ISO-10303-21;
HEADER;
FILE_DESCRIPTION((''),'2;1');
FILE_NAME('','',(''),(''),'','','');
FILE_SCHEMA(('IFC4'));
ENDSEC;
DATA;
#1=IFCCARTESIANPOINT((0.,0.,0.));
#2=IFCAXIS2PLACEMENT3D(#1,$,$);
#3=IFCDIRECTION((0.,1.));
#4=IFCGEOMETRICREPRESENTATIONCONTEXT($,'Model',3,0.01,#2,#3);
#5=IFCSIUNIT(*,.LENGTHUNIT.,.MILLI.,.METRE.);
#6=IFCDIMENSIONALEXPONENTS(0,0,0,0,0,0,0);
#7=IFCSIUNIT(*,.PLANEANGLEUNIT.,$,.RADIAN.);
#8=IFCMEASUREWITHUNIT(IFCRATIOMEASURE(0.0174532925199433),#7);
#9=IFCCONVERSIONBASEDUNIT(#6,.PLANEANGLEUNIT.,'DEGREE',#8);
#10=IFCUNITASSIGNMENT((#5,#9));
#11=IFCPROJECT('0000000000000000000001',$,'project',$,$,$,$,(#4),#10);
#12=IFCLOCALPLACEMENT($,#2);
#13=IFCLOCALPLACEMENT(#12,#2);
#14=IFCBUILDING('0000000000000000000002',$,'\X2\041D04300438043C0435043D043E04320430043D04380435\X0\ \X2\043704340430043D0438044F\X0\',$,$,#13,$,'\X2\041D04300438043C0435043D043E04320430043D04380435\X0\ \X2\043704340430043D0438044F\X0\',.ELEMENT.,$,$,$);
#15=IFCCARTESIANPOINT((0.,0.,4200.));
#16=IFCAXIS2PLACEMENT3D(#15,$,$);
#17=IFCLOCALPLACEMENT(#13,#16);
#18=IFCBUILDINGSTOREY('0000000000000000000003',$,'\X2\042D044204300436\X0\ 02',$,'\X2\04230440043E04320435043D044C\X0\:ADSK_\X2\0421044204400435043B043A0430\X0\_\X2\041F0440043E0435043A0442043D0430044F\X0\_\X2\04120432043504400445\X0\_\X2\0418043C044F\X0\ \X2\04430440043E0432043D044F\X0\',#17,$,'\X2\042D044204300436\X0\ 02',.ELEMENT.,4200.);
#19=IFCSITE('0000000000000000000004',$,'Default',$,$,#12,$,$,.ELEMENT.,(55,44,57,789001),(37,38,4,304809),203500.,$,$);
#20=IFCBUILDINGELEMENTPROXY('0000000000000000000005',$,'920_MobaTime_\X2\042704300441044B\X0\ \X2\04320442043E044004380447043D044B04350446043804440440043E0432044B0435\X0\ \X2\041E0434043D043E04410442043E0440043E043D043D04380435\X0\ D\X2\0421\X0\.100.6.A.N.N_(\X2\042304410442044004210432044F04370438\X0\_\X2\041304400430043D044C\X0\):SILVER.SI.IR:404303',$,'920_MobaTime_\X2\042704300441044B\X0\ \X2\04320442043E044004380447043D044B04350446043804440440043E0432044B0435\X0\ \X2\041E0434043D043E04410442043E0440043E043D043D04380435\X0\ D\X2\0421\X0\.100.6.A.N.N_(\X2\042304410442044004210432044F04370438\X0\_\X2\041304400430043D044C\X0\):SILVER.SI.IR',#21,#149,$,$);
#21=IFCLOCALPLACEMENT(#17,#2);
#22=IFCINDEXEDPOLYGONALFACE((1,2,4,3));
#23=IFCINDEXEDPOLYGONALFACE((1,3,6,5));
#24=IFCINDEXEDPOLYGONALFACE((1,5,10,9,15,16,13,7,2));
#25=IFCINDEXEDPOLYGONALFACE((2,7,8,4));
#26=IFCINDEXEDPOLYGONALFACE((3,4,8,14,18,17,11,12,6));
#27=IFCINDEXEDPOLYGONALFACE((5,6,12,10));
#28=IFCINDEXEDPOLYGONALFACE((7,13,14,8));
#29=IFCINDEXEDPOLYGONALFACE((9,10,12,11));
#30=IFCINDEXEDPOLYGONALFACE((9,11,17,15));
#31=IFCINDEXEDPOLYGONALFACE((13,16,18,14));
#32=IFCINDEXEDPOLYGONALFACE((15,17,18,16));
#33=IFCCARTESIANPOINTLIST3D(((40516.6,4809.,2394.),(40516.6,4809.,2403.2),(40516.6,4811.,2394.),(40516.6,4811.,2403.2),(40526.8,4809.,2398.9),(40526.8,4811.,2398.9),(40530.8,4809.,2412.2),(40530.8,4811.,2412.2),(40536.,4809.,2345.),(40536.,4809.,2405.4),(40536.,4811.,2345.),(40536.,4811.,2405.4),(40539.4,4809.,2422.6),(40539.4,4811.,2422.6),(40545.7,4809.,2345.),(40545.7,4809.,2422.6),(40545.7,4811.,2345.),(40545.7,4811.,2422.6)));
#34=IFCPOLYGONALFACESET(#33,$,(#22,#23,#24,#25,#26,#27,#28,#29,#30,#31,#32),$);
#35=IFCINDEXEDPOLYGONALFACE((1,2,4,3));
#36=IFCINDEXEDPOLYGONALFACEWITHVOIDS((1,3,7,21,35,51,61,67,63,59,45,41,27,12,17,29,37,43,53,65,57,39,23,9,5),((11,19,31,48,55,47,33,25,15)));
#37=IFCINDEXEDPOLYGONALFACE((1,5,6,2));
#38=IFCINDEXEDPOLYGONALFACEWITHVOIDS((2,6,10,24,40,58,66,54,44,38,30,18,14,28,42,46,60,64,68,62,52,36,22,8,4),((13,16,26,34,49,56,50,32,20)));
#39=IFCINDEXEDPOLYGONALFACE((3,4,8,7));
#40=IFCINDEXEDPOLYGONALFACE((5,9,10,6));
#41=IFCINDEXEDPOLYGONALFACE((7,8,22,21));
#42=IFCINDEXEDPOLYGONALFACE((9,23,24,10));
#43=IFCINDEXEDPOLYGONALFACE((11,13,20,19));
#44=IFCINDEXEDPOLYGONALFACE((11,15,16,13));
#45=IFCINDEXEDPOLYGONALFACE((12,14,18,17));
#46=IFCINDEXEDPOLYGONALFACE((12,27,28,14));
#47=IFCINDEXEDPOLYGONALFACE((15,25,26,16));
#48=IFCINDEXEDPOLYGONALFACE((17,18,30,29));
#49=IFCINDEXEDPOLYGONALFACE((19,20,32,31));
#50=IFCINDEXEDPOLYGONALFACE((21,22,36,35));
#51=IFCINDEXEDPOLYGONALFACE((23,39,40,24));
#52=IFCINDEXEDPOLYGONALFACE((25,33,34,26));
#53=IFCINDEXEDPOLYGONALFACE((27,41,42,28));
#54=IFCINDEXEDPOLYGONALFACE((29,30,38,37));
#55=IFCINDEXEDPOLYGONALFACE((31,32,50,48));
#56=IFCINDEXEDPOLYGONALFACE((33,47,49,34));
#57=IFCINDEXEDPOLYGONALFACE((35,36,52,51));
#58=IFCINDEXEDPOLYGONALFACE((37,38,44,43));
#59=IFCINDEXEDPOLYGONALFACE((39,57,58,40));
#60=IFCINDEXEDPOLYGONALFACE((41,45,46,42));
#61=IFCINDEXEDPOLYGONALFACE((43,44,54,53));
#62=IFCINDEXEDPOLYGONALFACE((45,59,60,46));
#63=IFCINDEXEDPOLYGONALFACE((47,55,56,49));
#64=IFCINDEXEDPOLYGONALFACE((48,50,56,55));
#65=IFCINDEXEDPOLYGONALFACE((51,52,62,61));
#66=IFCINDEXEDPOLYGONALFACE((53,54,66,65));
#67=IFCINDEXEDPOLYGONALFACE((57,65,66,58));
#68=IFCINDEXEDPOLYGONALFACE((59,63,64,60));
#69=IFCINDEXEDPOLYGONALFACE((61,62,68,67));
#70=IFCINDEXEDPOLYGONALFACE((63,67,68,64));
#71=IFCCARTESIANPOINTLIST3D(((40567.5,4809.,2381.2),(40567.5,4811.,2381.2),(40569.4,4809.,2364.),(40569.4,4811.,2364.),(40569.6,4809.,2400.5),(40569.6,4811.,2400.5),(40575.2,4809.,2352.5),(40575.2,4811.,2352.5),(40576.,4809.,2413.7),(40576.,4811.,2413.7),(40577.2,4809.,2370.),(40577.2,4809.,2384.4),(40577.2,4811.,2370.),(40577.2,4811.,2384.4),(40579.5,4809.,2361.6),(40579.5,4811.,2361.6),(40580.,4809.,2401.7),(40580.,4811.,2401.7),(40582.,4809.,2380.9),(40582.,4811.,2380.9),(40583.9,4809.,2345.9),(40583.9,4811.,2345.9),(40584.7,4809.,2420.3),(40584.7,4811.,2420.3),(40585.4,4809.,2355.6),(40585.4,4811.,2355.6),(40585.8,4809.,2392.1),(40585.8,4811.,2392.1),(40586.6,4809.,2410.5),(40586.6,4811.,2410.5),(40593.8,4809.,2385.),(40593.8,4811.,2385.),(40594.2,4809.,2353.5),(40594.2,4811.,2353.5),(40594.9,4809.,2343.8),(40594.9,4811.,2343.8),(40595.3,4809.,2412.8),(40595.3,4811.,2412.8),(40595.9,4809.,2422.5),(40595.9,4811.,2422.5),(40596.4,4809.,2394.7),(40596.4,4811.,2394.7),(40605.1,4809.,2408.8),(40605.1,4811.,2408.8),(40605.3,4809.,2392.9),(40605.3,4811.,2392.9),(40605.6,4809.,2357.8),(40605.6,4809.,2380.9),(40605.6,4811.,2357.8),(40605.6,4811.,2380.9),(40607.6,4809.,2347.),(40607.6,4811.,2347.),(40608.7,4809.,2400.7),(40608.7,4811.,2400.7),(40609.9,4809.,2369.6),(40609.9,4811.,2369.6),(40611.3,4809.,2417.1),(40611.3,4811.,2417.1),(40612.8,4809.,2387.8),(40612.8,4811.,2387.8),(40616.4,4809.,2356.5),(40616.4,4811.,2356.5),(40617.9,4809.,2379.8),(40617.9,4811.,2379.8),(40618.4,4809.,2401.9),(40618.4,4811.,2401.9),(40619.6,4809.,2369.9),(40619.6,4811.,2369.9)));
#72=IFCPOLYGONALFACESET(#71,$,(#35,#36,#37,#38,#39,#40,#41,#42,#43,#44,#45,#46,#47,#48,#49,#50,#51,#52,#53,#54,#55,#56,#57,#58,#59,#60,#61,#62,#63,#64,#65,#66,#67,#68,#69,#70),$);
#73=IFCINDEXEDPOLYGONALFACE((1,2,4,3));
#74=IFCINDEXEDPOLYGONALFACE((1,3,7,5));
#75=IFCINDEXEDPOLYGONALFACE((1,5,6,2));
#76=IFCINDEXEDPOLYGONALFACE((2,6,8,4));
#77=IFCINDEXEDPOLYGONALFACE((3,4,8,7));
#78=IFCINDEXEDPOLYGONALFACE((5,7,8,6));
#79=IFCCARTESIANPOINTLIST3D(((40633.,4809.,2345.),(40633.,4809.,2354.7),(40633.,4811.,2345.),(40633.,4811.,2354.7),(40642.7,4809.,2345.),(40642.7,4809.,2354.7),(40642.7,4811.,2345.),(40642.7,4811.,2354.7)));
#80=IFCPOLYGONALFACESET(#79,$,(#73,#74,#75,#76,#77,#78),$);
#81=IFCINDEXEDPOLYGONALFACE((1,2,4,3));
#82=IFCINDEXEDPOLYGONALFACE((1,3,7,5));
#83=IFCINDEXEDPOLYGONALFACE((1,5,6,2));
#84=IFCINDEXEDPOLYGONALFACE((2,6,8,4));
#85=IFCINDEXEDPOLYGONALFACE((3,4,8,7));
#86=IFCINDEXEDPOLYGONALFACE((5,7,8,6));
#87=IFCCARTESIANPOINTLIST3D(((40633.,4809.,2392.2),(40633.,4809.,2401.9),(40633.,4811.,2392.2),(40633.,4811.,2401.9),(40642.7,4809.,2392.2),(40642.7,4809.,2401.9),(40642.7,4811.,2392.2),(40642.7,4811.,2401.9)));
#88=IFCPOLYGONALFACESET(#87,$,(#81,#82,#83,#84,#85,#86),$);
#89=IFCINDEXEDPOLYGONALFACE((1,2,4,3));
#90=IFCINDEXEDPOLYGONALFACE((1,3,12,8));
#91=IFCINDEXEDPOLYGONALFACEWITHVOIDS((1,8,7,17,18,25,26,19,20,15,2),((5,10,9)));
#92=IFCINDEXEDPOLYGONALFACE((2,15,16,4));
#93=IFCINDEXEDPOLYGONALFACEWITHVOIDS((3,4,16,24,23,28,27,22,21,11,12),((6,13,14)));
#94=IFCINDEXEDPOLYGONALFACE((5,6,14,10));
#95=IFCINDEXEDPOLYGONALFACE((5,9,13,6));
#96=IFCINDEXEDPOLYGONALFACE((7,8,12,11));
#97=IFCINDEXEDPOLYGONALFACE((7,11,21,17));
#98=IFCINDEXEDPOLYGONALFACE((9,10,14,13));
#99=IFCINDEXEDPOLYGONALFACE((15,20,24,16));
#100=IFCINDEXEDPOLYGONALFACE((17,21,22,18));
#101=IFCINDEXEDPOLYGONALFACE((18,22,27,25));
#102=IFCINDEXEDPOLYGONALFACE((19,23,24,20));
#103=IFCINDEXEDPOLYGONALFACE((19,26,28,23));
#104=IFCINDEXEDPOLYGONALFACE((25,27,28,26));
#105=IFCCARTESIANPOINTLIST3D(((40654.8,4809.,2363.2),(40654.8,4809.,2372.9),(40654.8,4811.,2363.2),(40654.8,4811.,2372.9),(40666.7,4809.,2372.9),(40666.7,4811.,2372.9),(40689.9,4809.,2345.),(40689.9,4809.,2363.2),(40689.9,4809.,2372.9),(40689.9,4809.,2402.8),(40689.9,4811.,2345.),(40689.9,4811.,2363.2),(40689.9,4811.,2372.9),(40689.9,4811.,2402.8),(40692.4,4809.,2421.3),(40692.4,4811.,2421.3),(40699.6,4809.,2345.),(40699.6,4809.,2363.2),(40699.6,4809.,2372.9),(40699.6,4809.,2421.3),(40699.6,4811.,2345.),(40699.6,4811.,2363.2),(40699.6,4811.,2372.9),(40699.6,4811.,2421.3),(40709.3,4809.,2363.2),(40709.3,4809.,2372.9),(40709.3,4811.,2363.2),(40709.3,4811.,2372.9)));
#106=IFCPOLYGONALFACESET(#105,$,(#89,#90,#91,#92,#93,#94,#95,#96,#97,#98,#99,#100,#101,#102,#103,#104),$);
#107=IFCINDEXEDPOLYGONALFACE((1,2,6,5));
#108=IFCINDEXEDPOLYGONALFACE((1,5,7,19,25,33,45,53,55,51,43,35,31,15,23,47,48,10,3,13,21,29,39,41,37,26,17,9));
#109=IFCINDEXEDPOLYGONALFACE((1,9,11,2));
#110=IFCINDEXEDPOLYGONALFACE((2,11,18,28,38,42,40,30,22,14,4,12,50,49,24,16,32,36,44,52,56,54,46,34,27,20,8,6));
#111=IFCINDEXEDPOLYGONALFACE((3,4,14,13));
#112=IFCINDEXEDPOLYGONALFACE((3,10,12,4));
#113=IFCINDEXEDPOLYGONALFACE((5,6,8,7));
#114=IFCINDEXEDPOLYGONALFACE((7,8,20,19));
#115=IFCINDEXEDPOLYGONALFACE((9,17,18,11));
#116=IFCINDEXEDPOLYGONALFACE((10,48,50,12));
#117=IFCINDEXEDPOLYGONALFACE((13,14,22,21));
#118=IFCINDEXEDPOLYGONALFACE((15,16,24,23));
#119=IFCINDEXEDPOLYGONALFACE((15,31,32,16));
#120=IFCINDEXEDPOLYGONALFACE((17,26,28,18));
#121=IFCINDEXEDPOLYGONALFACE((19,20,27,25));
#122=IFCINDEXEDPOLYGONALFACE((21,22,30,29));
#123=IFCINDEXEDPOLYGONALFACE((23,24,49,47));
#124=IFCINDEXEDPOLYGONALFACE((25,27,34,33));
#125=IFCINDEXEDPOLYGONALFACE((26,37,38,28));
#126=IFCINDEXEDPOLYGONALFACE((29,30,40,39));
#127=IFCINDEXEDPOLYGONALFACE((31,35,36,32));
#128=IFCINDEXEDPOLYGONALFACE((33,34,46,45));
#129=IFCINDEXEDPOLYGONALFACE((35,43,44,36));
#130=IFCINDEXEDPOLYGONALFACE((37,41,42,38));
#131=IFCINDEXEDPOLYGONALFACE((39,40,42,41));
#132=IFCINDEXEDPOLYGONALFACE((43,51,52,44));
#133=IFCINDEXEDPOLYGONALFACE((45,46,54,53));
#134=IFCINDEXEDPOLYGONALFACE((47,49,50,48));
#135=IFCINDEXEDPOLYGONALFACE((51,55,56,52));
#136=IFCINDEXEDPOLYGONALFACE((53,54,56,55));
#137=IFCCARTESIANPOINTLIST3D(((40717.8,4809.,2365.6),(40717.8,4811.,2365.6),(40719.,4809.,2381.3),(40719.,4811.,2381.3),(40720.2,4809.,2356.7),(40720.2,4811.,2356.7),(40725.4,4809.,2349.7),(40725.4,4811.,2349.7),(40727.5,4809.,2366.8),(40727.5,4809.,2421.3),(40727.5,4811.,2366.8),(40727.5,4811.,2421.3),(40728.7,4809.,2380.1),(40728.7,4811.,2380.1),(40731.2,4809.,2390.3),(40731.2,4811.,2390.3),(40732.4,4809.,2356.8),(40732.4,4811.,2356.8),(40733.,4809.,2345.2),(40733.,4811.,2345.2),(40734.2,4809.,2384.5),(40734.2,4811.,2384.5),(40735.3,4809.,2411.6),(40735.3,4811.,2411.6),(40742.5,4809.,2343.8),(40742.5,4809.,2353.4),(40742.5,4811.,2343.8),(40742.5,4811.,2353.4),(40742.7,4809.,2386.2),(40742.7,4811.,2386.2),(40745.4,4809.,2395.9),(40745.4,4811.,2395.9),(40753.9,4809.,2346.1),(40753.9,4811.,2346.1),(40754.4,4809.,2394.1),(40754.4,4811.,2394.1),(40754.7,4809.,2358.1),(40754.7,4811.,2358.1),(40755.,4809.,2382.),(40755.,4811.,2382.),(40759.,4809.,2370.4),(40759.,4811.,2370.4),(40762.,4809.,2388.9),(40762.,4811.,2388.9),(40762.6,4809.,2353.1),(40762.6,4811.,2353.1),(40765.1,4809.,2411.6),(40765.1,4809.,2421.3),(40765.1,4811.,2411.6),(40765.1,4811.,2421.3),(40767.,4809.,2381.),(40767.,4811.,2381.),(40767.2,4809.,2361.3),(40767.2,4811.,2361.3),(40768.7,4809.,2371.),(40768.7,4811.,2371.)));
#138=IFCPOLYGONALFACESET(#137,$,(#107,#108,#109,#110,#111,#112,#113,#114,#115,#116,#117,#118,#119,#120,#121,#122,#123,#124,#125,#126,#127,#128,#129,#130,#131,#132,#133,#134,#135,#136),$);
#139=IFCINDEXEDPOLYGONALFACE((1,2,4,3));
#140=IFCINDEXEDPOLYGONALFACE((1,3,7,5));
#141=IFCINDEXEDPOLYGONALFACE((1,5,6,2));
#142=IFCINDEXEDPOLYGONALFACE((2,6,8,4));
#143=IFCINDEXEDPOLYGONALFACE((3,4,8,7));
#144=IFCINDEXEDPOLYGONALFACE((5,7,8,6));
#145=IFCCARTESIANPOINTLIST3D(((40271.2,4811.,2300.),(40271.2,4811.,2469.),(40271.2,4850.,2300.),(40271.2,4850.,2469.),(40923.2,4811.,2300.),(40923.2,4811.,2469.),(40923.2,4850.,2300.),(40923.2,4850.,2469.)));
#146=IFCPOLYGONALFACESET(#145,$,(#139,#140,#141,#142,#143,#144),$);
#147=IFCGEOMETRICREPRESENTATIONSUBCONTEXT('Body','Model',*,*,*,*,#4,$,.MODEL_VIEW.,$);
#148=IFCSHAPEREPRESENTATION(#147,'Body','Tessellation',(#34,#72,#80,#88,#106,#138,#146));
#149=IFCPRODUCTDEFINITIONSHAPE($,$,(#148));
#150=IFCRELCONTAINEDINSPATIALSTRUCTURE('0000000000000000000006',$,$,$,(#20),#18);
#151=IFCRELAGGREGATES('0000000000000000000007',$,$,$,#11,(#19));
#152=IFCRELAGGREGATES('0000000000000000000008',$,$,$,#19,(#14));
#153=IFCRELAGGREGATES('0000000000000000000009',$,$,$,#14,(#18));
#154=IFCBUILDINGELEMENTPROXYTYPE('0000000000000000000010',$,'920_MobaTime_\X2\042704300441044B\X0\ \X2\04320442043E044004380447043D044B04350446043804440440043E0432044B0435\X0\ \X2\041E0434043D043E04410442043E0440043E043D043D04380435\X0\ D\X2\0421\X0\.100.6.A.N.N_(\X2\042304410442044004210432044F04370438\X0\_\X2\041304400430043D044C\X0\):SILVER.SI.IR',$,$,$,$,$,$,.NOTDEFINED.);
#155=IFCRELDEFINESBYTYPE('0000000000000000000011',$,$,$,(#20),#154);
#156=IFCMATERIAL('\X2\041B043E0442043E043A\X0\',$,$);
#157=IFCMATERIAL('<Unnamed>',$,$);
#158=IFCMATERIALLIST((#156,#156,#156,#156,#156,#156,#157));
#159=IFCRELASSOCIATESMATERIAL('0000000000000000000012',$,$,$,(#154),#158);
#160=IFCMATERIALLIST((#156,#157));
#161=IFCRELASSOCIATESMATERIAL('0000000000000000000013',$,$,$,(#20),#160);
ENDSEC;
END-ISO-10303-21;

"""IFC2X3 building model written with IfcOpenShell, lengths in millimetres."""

from ifc_helpers import new_model, entity, si_unit, converted_unit, direction, frame, origin, origin_2d_with_axis, place, context, subcontext, project, spatial, polyline, rectangle, outline, extrude, source, transform, mapped, material, material_list, type_object, type_shapes, element, save


model = new_model("IFC2X3")

# Units and contexts
model_context = context("Model", 3, precision=0.01, world=origin(), true_north=direction((0.0, 1.0)))
body_context = subcontext(model_context, "Body", "Model", "MODEL_VIEW")
ifc_project = project(units=[si_unit("LENGTHUNIT", "METRE", prefix="MILLI"), converted_unit("PLANEANGLEUNIT", "DEGREE", entity("IfcRatioMeasure", 0.0174532925199433), si_unit("PLANEANGLEUNIT", "RADIAN"), dimensions=[0, 0, 0, 0, 0, 0, 0])], contexts=[model_context])

# Site, building, storey
site_placement = place(None, origin())
site = spatial("IfcSite", under=ifc_project, at=site_placement, Name="Default", CompositionType="ELEMENT", RefLatitude=(55, 44, 57, 789001), RefLongitude=(37, 38, 4, 304809), RefElevation=203500.0)
building_placement = place(site_placement, origin())
building = spatial("IfcBuilding", under=site, at=building_placement, Name="Наименование здания", LongName="Наименование здания", CompositionType="ELEMENT")
storey_placement = place(building_placement, frame((0.0, 0.0, 4200.0)))
storey = spatial("IfcBuildingStorey", under=building, at=storey_placement, Name="Этаж 02", ObjectType="Уровень:ADSK_Стрелка_Проектная_Вверх_Имя уровня", LongName="Этаж 02", CompositionType="ELEMENT", Elevation=4200.0)

# Building element proxy
ifc_material_1 = material(Name="Лоток")
ifc_material_2 = material(Name="<Unnamed>")
ifc_material_list_1 = material_list([ifc_material_1, ifc_material_2])
ifc_material_list_2 = material_list([ifc_material_1, ifc_material_1, ifc_material_1, ifc_material_1, ifc_material_1, ifc_material_1, ifc_material_2])
building_element_proxy_type_1 = type_object("IfcBuildingElementProxyType", Name="920_MobaTime_Часы вторичныецифровые Односторонние DС.100.6.A.N.N_(УстрСвязи_Грань):SILVER.SI.IR", PredefinedType="NOTDEFINED", material=ifc_material_list_2)
shared_shape_1 = source(origin(), body_context, "Body", "SweptSolid", [
    extrude(outline(polyline([(-49.3, -13.1), (28.2, -13.1), (28.2, -6.8), (17.9, 1.8), (8.8, 16.0), (-0.3, 16.0), (4.6, 5.8), (11.1, -3.4), (-49.3, -3.4), (-49.3, -13.1)])), frame((-64.6, 9.8, 39.0), z_axis=(0.0, 0.0, 1.0), x_axis=(0.0, 1.0, 0.0)), (0.0, 0.0, 1.0), 2.0),
    extrude(outline(polyline([(2.2, -27.6), (19.0, -27.6), (30.5, -16.1), (33.3, -4.9), (31.0, 5.8), (21.8, 17.2), (5.2, 27.3), (-11.1, 33.0), (-24.0, 32.7), (-33.6, 27.6), (-40.3, 18.6), (-42.8, 5.7), (-38.0, -6.3), (-27.2, -14.9), (-17.5, -17.7), (-8.2, -16.4), (-0.3, -11.9), (5.1, -4.5), (7.3, 6.2), (4.0, 17.2), (18.4, 7.3), (23.6, -2.4), (22.0, -11.4), (14.2, -18.4), (5.3, -18.3), (2.2, -27.6)]), holes=[polyline([(-9.0, 23.3), (-1.3, 14.3), (-2.5, 2.0), (-11.4, -7.0), (-23.4, -6.0), (-32.2, 2.9), (-31.2, 15.1), (-25.6, 22.1), (-17.5, 24.9), (-9.0, 23.3)])]), frame((-2.7, 3.6, 39.0), z_axis=(0.0, 0.0, 1.0), x_axis=(-0.427649, 0.903945, 0.0)), (0.0, 0.0, 1.0), 2.0),
    extrude(rectangle(XDim=9.7, YDim=9.7, at=origin_2d_with_axis()), frame((40.6, -34.7, 39.0)), (0.0, 0.0, 1.0), 2.0),
    extrude(rectangle(XDim=9.7, YDim=9.7, at=origin_2d_with_axis()), frame((40.6, 12.6, 39.0)), (0.0, 0.0, 1.0), 2.0),
    extrude(outline(polyline([(-0.9, -28.1), (8.8, -28.1), (8.8, -9.9), (18.5, -9.9), (18.5, -0.2), (8.8, -0.2), (8.8, 48.3), (1.5, 48.3), (-36.0, -0.2), (-36.0, -9.9), (-0.9, -9.9), (-0.9, -28.1)]), holes=[polyline([(-0.9, -0.2), (-24.1, -0.2), (-0.9, 29.7), (-0.9, -0.2)])]), frame((93.6, -11.4, 39.0)), (0.0, 0.0, 1.0), 2.0),
    extrude(outline(polyline([(3.3, -28.3), (12.5, -28.3), (20.5, -25.0), (26.8, -18.9), (30.7, -10.0), (31.4, 1.6), (26.9, 11.8), (20.1, 18.4), (11.1, 22.3), (1.0, 23.3), (-7.9, 20.4), (-14.9, 14.5), (-18.9, 6.2), (-17.1, -9.0), (-36.7, 0.5), (-29.1, 29.2), (-38.5, 31.7), (-48.1, -4.6), (-11.6, -23.1), (-8.0, -14.0), (-10.8, -7.6), (-10.2, 1.1), (-3.0, 11.8), (9.2, 12.8), (20.0, 5.5), (21.4, -7.5), (15.5, -16.4), (4.6, -18.6), (3.3, -28.3)])), frame((147.1, -8.5, 39.0), z_axis=(0.0, 0.0, 1.0), x_axis=(0.256974, -0.966418, 0.0)), (0.0, 0.0, 1.0), 2.0),
    extrude(rectangle(XDim=652.0, YDim=169.0, at=origin_2d_with_axis()), frame((0.0, 0.0, 0.0), z_axis=(0.0, 0.0, 1.0), x_axis=(-1.0, 0.0, 0.0)), (0.0, 0.0, 1.0), 39.0),
])
type_shapes(building_element_proxy_type_1, [shared_shape_1])
for number, where, z_axis, x_axis, name in (
    (1, (40597.2, 4850.0, 2384.5), (0.0, -1.0, 0.0), (1.0, 0.0, 0.0), "920_MobaTime_Часы вторичныецифровые Односторонние DС.100.6.A.N.N_(УстрСвязи_Грань):SILVER.SI.IR:404303"),
):
    element("IfcBuildingElementProxy", number, at=place(storey_placement, frame(where, z_axis=z_axis, x_axis=x_axis)), inside=storey, type_object=building_element_proxy_type_1, material=ifc_material_list_1, Name=name, ObjectType="920_MobaTime_Часы вторичныецифровые Односторонние DС.100.6.A.N.N_(УстрСвязи_Грань):SILVER.SI.IR", context=body_context, shape_type="MappedRepresentation", body=[
        mapped(shared_shape_1, transform((0.0, 0.0, 0.0), scale=1.0)),
    ])

save(model, "model.ifc")
